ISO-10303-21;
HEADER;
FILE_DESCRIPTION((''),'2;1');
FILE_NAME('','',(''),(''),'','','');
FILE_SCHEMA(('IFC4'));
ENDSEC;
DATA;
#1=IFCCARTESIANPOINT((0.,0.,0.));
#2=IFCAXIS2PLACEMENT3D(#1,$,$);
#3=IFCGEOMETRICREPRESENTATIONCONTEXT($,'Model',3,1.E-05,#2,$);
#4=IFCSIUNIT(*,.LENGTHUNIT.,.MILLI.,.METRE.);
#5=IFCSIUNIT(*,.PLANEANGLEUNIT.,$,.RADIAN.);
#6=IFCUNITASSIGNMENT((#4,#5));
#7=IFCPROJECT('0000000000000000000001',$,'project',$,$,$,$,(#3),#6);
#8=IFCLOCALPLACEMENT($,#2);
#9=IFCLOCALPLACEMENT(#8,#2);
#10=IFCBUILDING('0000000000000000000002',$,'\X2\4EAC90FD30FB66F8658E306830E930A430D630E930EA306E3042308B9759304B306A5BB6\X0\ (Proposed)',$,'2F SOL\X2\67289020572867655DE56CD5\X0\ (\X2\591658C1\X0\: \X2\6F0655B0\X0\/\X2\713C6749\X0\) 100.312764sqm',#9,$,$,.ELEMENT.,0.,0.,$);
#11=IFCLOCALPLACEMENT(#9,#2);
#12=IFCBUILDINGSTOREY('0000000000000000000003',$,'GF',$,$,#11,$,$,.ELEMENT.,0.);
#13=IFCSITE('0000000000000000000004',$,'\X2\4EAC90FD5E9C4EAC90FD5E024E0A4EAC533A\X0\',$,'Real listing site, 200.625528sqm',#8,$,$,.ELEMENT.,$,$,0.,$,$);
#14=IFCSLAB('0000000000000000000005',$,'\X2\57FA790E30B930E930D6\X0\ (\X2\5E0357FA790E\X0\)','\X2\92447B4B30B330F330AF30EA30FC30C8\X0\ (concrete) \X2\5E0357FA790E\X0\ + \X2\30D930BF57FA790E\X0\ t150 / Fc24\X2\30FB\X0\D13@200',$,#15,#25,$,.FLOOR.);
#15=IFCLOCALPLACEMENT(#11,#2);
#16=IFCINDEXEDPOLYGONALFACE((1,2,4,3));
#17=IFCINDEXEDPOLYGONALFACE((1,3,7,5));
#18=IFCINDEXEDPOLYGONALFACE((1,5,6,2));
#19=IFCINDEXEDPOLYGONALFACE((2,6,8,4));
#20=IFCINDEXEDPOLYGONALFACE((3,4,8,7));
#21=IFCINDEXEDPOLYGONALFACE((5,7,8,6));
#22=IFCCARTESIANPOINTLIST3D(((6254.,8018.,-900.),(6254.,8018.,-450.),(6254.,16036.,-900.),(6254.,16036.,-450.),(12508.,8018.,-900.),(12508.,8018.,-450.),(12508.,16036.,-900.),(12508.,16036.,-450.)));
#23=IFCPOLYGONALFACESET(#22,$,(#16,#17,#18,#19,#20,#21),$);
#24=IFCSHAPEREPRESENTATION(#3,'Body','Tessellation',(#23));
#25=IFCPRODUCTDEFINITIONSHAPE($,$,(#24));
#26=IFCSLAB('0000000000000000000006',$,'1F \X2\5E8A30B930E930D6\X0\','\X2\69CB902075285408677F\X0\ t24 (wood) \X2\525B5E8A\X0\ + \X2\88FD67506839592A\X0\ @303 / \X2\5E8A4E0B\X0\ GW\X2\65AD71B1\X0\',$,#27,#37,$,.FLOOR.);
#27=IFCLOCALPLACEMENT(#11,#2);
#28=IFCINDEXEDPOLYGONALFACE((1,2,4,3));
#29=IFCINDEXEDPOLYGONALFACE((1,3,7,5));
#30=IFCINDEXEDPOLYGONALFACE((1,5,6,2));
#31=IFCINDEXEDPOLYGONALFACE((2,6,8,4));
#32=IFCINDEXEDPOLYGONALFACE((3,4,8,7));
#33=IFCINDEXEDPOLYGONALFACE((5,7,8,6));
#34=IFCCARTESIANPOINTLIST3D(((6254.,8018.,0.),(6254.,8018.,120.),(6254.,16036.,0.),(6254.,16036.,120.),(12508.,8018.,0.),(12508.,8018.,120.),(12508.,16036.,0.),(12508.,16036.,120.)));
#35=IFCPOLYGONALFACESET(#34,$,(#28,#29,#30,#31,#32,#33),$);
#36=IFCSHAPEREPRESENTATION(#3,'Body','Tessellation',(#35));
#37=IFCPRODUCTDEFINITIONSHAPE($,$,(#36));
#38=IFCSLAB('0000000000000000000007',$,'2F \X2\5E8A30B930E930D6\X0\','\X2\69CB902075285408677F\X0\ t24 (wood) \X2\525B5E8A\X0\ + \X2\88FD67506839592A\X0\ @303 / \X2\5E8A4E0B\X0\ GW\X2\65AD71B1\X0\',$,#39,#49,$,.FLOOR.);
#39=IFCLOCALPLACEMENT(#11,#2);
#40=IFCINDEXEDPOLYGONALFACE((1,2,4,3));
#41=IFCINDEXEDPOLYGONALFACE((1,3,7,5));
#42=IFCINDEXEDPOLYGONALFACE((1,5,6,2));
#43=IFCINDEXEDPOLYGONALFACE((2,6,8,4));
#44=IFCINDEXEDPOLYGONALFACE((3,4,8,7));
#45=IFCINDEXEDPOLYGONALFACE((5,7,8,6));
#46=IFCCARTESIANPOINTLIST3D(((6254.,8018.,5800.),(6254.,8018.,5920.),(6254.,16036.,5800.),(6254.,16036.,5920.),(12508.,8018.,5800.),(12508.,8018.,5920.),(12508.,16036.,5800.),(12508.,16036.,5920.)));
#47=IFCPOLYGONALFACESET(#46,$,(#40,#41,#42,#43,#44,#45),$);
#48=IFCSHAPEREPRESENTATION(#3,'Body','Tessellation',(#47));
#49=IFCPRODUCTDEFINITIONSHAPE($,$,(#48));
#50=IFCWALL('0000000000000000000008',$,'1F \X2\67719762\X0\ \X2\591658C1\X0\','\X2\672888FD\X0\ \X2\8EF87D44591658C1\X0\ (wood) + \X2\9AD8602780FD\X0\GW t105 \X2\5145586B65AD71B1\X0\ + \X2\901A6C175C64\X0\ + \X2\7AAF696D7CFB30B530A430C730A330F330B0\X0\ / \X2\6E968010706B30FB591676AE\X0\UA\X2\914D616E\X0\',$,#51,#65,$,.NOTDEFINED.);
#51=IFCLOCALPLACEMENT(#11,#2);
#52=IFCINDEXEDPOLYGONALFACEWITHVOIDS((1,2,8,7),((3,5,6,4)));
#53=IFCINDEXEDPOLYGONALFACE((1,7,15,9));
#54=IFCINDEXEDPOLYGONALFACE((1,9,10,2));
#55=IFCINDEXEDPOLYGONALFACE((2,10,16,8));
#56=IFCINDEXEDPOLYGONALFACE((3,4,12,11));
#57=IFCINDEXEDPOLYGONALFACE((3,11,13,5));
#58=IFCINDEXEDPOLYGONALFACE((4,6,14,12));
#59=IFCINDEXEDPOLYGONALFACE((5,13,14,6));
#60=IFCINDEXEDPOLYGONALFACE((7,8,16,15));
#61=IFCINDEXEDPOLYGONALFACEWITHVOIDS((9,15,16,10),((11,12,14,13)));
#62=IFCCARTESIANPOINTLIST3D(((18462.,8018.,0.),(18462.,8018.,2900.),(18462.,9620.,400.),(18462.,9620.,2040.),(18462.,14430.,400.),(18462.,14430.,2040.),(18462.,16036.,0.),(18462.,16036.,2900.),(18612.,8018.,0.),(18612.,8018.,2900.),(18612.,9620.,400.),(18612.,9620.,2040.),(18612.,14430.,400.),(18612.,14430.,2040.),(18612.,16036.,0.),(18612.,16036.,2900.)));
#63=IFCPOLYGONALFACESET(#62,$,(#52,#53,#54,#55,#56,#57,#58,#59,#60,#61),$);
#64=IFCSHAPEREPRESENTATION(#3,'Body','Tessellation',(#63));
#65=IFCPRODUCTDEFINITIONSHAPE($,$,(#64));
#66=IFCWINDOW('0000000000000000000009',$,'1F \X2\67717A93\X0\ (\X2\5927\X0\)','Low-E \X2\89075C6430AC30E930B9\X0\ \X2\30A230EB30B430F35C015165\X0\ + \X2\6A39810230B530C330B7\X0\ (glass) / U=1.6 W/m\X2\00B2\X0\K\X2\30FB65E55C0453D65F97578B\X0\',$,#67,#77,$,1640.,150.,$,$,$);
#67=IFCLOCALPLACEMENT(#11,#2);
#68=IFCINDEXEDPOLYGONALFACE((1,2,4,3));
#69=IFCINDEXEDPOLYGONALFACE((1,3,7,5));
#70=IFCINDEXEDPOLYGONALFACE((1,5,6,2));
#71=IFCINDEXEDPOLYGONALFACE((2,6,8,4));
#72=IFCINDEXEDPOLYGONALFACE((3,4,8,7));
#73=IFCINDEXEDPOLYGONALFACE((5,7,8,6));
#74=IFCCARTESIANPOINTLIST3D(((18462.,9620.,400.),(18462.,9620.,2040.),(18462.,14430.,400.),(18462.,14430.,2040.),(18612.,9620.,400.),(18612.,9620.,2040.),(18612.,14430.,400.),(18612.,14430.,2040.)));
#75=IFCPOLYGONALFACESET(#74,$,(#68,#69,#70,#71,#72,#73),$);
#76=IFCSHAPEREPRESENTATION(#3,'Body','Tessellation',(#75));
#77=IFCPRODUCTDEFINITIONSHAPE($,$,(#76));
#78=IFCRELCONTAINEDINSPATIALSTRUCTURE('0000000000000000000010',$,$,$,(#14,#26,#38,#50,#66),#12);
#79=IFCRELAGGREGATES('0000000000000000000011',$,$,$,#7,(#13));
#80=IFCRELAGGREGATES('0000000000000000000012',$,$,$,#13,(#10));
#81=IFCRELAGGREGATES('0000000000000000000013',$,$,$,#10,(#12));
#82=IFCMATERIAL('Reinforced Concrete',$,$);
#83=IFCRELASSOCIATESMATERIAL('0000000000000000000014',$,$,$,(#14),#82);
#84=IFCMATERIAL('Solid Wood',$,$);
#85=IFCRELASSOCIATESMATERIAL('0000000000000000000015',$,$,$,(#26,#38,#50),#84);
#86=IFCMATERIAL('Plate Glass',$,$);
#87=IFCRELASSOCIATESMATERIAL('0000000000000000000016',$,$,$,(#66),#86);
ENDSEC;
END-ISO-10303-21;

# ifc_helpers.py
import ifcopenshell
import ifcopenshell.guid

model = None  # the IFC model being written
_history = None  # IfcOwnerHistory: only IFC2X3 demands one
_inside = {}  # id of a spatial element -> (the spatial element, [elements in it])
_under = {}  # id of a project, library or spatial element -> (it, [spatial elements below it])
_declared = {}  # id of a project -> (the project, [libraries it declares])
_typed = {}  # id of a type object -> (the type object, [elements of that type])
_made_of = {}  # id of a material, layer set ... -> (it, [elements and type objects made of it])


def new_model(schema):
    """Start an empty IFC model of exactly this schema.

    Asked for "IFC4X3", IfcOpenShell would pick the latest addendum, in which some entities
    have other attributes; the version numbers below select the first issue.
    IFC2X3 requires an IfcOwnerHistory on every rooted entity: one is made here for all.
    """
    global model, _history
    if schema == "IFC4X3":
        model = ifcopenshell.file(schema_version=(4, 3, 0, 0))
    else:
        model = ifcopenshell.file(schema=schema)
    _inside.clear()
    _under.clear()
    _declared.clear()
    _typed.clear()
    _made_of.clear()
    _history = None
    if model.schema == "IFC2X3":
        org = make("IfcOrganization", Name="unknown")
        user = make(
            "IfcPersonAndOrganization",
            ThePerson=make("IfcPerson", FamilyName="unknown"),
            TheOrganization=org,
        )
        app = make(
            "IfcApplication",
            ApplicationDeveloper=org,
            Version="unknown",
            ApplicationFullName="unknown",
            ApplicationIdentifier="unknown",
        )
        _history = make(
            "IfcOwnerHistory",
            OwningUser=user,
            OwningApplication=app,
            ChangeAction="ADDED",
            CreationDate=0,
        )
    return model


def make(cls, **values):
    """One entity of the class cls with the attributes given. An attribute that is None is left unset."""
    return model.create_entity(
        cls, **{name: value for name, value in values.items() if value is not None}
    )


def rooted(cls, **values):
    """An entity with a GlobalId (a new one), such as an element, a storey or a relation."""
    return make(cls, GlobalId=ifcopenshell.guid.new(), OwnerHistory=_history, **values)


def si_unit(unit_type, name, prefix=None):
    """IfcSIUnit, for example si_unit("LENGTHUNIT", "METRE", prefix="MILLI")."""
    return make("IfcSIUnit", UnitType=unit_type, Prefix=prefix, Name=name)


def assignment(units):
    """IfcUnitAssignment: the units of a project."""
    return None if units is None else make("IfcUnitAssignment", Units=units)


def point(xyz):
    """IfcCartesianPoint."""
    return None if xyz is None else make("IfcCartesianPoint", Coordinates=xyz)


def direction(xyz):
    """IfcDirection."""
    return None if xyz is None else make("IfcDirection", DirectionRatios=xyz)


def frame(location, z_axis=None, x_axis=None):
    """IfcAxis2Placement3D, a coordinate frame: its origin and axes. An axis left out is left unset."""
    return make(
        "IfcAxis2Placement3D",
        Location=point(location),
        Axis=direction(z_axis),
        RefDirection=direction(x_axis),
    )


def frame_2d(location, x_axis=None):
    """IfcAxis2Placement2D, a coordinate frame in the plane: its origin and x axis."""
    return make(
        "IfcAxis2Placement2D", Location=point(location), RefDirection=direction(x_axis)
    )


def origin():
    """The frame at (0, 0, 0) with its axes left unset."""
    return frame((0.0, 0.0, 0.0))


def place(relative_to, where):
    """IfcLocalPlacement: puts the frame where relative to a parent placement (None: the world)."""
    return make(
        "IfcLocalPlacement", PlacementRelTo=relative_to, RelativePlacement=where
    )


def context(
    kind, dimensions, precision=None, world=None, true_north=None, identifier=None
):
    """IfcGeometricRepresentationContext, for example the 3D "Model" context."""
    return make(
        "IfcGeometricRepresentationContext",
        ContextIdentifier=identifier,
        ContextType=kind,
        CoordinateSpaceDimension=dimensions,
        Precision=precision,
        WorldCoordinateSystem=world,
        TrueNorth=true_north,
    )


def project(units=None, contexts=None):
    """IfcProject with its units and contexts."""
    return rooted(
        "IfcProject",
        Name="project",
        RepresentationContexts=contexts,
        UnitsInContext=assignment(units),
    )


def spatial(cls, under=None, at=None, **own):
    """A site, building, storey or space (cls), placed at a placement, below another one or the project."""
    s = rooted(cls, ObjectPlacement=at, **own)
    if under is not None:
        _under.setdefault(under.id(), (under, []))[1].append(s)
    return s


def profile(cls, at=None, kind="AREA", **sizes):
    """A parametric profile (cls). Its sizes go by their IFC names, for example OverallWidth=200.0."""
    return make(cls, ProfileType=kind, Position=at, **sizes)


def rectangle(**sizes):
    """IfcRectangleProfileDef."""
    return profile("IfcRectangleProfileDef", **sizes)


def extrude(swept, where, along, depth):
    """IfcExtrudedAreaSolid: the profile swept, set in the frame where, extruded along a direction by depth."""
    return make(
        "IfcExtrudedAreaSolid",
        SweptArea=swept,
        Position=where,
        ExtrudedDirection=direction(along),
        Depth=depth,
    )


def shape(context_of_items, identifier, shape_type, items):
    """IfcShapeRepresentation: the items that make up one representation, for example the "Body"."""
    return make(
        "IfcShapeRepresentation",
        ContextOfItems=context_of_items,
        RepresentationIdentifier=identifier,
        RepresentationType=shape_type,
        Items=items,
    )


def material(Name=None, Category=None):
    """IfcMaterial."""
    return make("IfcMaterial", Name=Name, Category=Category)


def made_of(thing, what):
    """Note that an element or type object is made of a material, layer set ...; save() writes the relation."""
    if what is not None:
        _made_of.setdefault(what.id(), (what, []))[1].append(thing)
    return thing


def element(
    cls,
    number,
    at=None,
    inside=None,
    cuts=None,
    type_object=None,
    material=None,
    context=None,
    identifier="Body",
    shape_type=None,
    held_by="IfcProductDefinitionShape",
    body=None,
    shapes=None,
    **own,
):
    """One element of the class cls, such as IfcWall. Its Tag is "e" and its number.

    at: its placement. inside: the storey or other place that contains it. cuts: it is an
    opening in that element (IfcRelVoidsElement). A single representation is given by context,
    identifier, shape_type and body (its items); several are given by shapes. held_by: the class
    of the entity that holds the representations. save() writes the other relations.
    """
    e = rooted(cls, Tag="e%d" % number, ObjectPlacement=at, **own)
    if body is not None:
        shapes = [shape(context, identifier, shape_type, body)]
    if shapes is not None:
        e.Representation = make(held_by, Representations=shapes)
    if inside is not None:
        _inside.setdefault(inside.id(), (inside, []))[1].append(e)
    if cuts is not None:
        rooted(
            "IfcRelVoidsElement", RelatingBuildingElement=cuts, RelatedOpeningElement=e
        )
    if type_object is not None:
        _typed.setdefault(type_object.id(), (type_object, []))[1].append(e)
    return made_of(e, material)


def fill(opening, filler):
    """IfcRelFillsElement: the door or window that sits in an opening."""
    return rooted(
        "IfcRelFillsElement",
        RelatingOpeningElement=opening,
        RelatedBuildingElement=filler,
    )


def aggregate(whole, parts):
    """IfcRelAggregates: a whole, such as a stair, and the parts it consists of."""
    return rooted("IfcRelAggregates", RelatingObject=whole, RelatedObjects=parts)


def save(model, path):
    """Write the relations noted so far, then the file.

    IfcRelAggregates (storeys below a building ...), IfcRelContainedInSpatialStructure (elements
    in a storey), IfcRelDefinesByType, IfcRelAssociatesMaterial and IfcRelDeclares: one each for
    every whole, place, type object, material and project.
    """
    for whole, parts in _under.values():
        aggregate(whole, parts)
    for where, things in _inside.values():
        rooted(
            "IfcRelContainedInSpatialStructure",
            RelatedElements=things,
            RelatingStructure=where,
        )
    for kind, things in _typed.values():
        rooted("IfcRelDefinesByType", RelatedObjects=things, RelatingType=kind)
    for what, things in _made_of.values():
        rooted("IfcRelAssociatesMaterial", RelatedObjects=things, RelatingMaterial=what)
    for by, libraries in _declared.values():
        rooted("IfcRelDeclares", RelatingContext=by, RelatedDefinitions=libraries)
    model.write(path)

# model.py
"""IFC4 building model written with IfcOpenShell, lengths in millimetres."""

from ifc_helpers import new_model, si_unit, frame, frame_2d, origin, place, context, project, spatial, rectangle, extrude, material, element, fill, save


model = new_model("IFC4")

# Units and contexts
model_context = context("Model", 3, precision=1e-05, world=origin())
ifc_project = project(units=[si_unit("LENGTHUNIT", "METRE", prefix="MILLI"), si_unit("PLANEANGLEUNIT", "RADIAN")], contexts=[model_context])

# Site, building, storey
site_placement = place(None, origin())
site = spatial("IfcSite", under=ifc_project, at=site_placement, Name="京都府京都市上京区", ObjectType="Real listing site, 200.625528sqm", CompositionType="ELEMENT", RefElevation=0.0)
building_placement = place(site_placement, origin())
building = spatial("IfcBuilding", under=site, at=building_placement, Name="京都・書斎とライブラリのある静かな家 (Proposed)", ObjectType="2F SOL木造在来工法 (外壁: 漆喰/焼杉) 100.312764sqm", CompositionType="ELEMENT", ElevationOfRefHeight=0.0, ElevationOfTerrain=0.0)
storey_placement = place(building_placement, origin())
storey = spatial("IfcBuildingStorey", under=building, at=storey_placement, Name="GF", CompositionType="ELEMENT", Elevation=0.0)

# Slabs
ifc_material_1 = material(Name="Reinforced Concrete")
slab_1_placement = place(storey_placement, frame((3127.0, 4009.0, -450.0)))
element("IfcSlab", 1, at=slab_1_placement, inside=storey, material=ifc_material_1, Name="基礎スラブ (布基礎)", Description="鉄筋コンクリート (concrete) 布基礎 + ベタ基礎 t150 / Fc24・D13@200", PredefinedType="FLOOR", context=model_context, shape_type="SweptSolid", body=[
    extrude(rectangle(XDim=6254.0, YDim=8018.0, at=frame_2d((3127.0, 4009.0))), frame((3127.0, 4009.0, -450.0)), (0.0, 0.0, 1.0), 450.0),
])
ifc_material_2 = material(Name="Solid Wood")
slab_2_placement = place(storey_placement, frame((3127.0, 4009.0, 0.0)))
element("IfcSlab", 2, at=slab_2_placement, inside=storey, material=ifc_material_2, Name="1F 床スラブ", Description="構造用合板 t24 (wood) 剛床 + 製材根太 @303 / 床下 GW断熱", PredefinedType="FLOOR", context=model_context, shape_type="SweptSolid", body=[
    extrude(rectangle(XDim=6254.0, YDim=8018.0, at=frame_2d((3127.0, 4009.0))), frame((3127.0, 4009.0, 0.0)), (0.0, 0.0, 1.0), 120.0),
])
slab_3_placement = place(storey_placement, frame((3127.0, 4009.0, 2900.0)))
element("IfcSlab", 3, at=slab_3_placement, inside=storey, material=ifc_material_2, Name="2F 床スラブ", Description="構造用合板 t24 (wood) 剛床 + 製材根太 @303 / 床下 GW断熱", PredefinedType="FLOOR", context=model_context, shape_type="SweptSolid", body=[
    extrude(rectangle(XDim=6254.0, YDim=8018.0, at=frame_2d((3127.0, 4009.0))), frame((3127.0, 4009.0, 2900.0)), (0.0, 0.0, 1.0), 120.0),
])

# Shared definitions
ifc_material_3 = material(Name="Plate Glass")

# Wall, opening, window
wall_1_placement = place(storey_placement, frame((9231.0, 4009.0, 0.0)))
wall_1 = element("IfcWall", 4, at=wall_1_placement, inside=storey, material=ifc_material_2, Name="1F 東面 外壁", Description="木製 軸組外壁 (wood) + 高性能GW t105 充填断熱 + 通気層 + 窯業系サイディング / 準耐火・外皮UA配慮", PredefinedType="NOTDEFINED", context=model_context, shape_type="SweptSolid", body=[
    extrude(rectangle(XDim=150.0, YDim=8018.0, at=frame_2d((75.0, 4009.0))), frame((9231.0, 4009.0, 0.0)), (0.0, 0.0, 1.0), 2900.0),
])
opening_1_placement = place(storey_placement, frame((9231.0, 4810.0, 200.0)))
opening_1 = element("IfcOpeningElement", 5, at=opening_1_placement, cuts=wall_1, PredefinedType="NOTDEFINED", context=model_context, shape_type="SweptSolid", body=[
    extrude(rectangle(XDim=150.0, YDim=4810.0, at=frame_2d((75.0, 2405.0))), frame((9231.0, 4810.0, 200.0)), (0.0, 0.0, 1.0), 1640.0),
])
window_1_placement = place(storey_placement, frame((9231.0, 4810.0, 200.0)))
window_1 = element("IfcWindow", 6, at=window_1_placement, inside=storey, material=ifc_material_3, Name="1F 東窓 (大)", Description="Low-E 複層ガラス アルゴン封入 + 樹脂サッシ (glass) / U=1.6 W/m²K・日射取得型", OverallHeight=1640.0, OverallWidth=150.0, context=model_context, shape_type="SweptSolid", body=[
    extrude(rectangle(XDim=150.0, YDim=4810.0, at=frame_2d((75.0, 2405.0))), frame((9231.0, 4810.0, 200.0)), (0.0, 0.0, 1.0), 1640.0),
])
fill(opening_1, window_1)

save(model, "model.ifc")
